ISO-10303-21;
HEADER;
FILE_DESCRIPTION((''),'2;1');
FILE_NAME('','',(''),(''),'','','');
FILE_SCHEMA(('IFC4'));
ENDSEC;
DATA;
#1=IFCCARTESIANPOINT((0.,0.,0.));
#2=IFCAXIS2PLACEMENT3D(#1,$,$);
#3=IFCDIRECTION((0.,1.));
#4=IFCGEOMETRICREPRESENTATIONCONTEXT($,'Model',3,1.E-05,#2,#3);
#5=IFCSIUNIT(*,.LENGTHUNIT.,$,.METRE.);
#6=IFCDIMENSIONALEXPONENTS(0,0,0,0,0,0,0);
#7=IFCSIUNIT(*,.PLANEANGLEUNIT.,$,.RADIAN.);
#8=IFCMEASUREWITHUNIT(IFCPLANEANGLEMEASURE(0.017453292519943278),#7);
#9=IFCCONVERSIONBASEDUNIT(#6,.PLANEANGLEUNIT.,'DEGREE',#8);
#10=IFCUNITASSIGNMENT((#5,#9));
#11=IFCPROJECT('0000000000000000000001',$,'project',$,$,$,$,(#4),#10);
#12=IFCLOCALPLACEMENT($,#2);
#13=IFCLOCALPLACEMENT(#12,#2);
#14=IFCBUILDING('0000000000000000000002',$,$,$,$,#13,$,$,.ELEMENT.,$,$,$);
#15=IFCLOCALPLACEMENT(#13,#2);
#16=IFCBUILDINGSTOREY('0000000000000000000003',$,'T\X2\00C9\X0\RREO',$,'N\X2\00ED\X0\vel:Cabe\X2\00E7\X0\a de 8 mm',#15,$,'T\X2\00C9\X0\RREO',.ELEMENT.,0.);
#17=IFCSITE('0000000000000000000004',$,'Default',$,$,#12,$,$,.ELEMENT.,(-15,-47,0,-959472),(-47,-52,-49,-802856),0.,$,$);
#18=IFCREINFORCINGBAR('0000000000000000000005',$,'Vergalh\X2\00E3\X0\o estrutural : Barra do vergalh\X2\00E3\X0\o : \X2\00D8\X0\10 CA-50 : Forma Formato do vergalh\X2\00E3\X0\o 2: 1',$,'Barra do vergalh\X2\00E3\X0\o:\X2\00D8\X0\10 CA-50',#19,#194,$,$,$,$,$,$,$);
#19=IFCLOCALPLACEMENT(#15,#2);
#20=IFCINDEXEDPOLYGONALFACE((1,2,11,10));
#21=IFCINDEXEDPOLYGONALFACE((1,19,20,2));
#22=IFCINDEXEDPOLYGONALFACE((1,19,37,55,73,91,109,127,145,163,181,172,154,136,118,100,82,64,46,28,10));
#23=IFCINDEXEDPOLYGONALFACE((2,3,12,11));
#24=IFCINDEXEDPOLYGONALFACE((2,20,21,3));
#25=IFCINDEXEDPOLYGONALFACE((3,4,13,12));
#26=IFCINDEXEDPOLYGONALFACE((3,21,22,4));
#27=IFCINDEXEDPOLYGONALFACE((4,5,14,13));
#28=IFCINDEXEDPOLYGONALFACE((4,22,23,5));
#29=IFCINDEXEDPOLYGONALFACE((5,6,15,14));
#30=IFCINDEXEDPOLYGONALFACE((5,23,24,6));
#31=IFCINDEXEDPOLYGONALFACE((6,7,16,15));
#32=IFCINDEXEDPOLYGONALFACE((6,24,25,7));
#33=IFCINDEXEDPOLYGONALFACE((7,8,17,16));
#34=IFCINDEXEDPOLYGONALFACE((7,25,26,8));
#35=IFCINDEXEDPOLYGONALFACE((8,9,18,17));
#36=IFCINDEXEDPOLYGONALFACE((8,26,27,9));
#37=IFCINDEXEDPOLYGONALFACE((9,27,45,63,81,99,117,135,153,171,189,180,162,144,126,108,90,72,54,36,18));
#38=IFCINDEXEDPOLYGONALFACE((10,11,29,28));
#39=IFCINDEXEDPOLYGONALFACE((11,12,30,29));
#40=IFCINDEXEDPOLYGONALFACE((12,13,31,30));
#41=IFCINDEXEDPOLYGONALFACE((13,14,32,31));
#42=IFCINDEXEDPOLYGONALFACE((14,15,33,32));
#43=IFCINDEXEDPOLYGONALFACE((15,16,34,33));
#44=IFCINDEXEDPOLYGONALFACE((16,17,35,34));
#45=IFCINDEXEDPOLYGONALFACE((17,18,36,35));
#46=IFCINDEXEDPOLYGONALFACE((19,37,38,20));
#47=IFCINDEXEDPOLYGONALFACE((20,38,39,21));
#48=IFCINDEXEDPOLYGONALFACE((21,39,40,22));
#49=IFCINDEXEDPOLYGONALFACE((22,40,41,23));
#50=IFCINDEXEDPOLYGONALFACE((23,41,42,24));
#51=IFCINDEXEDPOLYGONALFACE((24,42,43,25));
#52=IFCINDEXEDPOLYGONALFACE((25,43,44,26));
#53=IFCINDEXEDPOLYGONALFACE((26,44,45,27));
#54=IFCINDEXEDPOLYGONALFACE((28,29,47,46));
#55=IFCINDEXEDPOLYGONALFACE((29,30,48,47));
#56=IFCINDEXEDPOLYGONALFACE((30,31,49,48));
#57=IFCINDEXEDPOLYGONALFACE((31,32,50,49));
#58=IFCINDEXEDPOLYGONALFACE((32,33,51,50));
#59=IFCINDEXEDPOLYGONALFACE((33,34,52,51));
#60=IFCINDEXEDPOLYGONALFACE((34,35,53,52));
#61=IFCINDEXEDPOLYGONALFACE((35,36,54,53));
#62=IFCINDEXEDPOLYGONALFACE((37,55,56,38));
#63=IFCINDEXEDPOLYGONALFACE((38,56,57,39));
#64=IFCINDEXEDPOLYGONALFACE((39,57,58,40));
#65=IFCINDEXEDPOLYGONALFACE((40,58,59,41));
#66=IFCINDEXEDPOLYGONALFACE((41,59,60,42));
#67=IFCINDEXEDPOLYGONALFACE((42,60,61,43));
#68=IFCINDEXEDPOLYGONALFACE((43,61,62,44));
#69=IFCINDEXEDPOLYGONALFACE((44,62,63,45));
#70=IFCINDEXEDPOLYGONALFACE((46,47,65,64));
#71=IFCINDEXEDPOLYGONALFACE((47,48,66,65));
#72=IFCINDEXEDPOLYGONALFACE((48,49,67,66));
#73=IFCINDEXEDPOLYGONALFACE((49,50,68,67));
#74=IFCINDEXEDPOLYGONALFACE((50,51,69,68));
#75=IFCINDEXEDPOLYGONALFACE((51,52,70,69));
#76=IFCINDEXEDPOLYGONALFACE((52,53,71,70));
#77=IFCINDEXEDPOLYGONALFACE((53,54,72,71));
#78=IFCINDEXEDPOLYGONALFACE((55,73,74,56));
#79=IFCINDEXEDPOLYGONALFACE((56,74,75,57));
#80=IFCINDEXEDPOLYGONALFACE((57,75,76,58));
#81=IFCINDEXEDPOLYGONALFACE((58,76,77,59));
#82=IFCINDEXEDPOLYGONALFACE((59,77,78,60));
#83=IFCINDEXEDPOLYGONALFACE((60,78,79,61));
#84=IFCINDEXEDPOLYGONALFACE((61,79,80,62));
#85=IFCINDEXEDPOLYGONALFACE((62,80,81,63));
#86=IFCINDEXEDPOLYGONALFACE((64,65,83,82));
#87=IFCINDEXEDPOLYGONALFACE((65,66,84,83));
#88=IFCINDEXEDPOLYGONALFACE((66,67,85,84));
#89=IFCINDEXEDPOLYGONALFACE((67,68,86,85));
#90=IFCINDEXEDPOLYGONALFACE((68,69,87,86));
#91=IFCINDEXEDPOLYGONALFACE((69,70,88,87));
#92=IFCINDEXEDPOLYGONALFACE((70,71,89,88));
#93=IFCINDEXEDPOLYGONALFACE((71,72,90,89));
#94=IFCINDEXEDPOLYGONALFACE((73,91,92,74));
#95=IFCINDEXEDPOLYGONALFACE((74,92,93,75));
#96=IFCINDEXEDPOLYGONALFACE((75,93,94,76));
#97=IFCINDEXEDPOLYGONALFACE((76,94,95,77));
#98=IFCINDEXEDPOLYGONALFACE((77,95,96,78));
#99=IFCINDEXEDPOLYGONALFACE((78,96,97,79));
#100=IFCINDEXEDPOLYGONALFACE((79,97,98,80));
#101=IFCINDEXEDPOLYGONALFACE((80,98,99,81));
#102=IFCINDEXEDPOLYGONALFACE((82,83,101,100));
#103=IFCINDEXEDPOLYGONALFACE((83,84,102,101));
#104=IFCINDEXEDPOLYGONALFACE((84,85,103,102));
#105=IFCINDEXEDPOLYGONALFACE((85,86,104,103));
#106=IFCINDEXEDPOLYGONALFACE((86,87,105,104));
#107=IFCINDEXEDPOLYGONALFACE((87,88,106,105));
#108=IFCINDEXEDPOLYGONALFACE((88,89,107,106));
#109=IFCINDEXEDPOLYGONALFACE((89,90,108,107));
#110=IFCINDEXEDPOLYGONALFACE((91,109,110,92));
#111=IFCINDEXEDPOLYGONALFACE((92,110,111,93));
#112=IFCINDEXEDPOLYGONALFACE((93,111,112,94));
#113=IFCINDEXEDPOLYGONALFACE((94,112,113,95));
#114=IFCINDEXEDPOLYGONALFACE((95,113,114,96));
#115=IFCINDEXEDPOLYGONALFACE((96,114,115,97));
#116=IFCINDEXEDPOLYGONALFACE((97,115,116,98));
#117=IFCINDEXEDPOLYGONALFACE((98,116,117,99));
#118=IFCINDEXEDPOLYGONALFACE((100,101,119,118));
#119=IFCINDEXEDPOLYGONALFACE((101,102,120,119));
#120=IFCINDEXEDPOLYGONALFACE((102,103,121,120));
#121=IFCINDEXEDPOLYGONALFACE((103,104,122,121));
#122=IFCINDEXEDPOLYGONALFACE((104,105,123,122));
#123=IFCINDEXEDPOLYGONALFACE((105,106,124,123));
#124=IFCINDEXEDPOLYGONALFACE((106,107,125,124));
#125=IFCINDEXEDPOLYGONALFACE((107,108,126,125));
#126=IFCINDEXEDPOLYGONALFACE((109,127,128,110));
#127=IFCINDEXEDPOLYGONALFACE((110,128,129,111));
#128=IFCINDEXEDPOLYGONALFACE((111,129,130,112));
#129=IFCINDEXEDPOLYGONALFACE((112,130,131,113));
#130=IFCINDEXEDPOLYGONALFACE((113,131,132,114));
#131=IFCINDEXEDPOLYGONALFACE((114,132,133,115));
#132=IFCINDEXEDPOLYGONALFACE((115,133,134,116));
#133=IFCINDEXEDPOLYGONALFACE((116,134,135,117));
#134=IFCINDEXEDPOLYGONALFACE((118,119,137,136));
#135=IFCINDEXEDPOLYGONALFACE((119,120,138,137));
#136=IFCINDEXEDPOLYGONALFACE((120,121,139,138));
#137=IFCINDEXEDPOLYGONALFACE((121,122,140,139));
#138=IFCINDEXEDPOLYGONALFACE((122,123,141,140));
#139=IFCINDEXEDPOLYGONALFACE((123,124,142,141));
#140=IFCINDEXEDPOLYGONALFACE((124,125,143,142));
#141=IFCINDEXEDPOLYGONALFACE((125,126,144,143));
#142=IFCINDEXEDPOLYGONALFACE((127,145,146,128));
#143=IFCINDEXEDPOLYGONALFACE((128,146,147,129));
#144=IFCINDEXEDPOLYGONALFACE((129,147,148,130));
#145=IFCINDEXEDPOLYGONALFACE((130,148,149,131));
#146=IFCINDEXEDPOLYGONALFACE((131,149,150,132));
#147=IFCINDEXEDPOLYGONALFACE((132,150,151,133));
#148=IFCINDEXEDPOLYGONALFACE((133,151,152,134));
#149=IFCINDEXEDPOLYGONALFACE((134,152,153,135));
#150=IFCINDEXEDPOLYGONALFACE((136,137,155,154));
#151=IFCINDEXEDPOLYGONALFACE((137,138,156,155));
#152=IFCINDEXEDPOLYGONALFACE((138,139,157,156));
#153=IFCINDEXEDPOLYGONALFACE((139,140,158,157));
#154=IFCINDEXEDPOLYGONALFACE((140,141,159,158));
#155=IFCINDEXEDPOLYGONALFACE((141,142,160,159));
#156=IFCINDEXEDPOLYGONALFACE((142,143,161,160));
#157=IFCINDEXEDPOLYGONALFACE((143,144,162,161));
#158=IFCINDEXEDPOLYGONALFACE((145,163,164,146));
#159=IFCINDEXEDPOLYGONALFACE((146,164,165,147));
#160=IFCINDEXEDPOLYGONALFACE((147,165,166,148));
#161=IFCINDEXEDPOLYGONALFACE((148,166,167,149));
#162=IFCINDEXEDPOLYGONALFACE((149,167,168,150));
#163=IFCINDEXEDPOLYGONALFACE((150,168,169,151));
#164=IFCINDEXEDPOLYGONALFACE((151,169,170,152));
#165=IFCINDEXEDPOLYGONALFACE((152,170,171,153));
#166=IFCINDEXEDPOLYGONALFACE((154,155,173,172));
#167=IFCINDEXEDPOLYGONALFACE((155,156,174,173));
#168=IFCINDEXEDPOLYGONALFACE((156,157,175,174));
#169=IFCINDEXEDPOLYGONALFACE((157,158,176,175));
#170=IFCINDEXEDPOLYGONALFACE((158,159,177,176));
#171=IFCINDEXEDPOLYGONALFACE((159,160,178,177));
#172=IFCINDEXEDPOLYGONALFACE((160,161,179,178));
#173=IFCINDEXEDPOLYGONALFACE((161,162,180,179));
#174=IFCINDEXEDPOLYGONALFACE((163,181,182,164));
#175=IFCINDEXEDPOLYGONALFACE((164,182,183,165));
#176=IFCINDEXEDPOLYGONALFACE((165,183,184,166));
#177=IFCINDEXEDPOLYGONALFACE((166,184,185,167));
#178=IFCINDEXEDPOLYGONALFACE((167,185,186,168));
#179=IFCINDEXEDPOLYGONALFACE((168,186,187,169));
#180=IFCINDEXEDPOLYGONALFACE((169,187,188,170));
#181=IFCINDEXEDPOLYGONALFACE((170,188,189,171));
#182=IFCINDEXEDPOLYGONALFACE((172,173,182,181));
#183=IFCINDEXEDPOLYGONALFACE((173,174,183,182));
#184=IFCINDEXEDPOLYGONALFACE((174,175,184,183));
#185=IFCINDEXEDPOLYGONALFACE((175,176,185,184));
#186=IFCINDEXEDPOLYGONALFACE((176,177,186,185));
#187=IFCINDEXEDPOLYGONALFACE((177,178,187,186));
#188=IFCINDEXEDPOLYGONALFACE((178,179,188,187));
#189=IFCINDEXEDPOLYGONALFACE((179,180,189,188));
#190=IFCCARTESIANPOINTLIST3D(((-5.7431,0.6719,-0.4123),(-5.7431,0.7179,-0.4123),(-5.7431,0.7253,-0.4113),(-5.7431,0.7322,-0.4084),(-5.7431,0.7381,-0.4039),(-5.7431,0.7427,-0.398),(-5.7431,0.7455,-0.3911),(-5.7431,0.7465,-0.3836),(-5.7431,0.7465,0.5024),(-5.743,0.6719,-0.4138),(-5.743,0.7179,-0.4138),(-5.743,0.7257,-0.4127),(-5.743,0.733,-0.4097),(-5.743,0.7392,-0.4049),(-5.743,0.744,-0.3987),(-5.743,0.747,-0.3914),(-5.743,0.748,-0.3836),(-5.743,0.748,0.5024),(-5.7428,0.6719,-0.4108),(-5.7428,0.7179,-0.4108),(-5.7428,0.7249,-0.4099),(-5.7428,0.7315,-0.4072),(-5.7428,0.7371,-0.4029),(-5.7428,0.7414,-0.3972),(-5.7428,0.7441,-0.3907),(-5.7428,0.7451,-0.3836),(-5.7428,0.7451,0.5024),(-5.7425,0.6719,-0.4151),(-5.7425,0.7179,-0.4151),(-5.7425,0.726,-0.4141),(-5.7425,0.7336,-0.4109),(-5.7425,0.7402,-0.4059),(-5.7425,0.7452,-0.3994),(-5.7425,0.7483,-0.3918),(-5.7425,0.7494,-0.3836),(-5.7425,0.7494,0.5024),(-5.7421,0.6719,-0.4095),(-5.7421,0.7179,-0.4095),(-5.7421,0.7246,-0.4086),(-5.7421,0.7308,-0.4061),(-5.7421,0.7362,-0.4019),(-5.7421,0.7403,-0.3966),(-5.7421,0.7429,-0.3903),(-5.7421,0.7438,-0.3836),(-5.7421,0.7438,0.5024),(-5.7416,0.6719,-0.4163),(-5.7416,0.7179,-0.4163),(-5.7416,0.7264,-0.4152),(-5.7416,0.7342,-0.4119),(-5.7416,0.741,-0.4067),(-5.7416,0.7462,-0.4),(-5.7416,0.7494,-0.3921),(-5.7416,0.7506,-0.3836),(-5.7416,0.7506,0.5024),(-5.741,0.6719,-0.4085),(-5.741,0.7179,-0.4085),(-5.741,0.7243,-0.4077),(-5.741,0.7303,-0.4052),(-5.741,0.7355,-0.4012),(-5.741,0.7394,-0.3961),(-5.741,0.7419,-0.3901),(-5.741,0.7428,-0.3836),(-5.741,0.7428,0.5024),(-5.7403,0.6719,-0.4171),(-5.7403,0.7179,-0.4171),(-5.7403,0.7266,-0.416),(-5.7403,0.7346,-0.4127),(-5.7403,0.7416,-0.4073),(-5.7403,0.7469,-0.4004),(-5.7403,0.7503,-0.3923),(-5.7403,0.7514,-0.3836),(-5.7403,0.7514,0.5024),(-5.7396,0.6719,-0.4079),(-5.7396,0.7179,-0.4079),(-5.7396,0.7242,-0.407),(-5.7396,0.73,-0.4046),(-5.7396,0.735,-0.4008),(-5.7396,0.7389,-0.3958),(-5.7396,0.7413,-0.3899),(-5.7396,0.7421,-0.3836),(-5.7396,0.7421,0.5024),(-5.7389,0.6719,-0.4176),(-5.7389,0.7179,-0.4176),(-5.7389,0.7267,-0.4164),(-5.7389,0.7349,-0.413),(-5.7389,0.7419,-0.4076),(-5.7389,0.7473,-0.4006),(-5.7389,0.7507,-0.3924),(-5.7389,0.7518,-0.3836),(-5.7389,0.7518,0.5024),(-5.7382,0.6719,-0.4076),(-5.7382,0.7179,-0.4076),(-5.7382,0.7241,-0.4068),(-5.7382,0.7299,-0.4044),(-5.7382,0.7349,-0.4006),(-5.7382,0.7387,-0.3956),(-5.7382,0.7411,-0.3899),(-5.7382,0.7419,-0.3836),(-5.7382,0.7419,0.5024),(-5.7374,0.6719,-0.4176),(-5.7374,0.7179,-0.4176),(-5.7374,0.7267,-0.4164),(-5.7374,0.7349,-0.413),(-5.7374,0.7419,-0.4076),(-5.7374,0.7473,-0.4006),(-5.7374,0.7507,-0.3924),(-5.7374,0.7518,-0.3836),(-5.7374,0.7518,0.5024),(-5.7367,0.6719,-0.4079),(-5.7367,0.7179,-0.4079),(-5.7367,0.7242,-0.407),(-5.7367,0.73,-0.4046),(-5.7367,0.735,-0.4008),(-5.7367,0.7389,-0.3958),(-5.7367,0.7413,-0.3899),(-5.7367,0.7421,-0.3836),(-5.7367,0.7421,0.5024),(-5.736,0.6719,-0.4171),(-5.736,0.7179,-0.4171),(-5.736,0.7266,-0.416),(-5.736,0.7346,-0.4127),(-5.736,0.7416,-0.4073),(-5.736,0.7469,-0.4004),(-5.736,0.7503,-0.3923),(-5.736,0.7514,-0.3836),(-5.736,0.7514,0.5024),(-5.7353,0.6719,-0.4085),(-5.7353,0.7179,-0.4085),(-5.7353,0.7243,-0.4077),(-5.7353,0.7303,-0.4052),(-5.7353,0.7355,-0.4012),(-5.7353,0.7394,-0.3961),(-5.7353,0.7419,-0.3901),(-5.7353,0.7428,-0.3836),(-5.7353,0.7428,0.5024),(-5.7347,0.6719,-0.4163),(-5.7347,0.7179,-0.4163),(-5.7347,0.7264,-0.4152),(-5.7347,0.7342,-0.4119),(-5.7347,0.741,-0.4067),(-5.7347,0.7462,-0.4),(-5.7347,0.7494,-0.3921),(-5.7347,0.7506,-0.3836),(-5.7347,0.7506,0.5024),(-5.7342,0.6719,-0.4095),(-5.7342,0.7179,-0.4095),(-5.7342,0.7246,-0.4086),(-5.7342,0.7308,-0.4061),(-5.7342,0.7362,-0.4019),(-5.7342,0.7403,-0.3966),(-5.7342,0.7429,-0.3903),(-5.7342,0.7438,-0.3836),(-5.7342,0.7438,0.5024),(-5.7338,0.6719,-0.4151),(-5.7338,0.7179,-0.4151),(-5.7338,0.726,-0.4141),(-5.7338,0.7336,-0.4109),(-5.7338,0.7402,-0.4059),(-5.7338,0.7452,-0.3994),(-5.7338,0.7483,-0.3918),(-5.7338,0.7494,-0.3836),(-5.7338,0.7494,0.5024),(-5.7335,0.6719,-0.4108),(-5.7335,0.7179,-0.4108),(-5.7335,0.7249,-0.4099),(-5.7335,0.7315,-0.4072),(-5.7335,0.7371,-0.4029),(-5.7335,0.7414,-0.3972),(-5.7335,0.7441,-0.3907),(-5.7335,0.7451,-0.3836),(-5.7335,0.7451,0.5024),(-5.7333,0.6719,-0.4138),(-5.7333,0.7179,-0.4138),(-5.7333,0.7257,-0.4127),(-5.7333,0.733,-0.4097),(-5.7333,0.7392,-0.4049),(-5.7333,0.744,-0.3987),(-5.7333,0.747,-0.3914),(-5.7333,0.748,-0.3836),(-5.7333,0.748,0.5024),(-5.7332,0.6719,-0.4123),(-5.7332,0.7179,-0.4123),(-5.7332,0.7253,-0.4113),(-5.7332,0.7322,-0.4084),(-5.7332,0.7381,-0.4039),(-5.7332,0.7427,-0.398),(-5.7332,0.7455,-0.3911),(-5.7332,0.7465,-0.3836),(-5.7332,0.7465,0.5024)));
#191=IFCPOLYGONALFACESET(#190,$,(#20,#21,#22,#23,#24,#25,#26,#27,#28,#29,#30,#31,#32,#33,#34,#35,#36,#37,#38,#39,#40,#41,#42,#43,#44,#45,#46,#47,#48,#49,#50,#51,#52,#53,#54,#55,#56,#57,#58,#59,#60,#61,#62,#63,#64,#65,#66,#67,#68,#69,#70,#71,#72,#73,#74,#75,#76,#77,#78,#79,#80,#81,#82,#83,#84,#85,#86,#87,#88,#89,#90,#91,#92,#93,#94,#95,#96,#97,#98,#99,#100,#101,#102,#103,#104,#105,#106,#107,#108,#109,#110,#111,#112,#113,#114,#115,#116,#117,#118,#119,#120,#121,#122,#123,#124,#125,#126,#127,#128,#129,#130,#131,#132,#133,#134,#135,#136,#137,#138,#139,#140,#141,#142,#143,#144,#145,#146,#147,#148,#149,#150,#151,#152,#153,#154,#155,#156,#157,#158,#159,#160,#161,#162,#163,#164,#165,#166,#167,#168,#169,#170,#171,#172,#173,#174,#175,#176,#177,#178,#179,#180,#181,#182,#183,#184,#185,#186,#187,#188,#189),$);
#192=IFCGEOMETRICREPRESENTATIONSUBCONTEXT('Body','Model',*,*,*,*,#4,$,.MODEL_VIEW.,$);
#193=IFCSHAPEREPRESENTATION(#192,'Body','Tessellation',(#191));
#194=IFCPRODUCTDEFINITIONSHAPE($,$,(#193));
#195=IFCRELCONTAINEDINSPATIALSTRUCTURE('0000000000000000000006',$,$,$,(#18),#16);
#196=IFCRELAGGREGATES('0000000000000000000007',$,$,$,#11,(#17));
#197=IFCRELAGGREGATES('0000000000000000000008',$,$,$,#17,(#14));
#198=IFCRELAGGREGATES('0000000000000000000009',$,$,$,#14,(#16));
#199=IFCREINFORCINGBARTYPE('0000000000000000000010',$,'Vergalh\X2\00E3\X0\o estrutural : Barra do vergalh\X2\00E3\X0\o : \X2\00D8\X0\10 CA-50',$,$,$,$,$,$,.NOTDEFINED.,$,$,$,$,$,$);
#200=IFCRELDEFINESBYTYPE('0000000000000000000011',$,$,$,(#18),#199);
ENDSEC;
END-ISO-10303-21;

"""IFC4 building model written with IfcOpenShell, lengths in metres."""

from ifc_helpers import new_model, entity, si_unit, converted_unit, direction, origin, place, context, subcontext, project, spatial, type_object, element, save


model = new_model("IFC4")

# Units and contexts
model_context = context("Model", 3, precision=1e-05, world=origin(), true_north=direction((0.0, 1.0)))
body_context = subcontext(model_context, "Body", "Model", "MODEL_VIEW")
ifc_project = project(units=[si_unit("LENGTHUNIT", "METRE"), converted_unit("PLANEANGLEUNIT", "DEGREE", entity("IfcPlaneAngleMeasure", 0.017453292519943278), si_unit("PLANEANGLEUNIT", "RADIAN"), dimensions=[0, 0, 0, 0, 0, 0, 0])], contexts=[model_context])

# Site, building, storey
site_placement = place(None, origin())
site = spatial("IfcSite", under=ifc_project, at=site_placement, Name="Default", CompositionType="ELEMENT", RefLatitude=(-15, -47, 0, -959472), RefLongitude=(-47, -52, -49, -802856), RefElevation=0.0)
building_placement = place(site_placement, origin())
building = spatial("IfcBuilding", under=site, at=building_placement, CompositionType="ELEMENT")
storey_placement = place(building_placement, origin())
storey = spatial("IfcBuildingStorey", under=building, at=storey_placement, Name="TÉRREO", ObjectType="Nível:Cabeça de 8 mm", LongName="TÉRREO", CompositionType="ELEMENT", Elevation=0.0)

# Reinforcing bar
reinforcing_bar_type_1 = type_object("IfcReinforcingBarType", Name="Vergalhão estrutural : Barra do vergalhão : Ø10 CA-50", PredefinedType="NOTDEFINED")
reinforcing_bar_1_placement = place(storey_placement, origin())
element("IfcReinforcingBar", 1, at=reinforcing_bar_1_placement, inside=storey, type_object=reinforcing_bar_type_1, Name="Vergalhão estrutural : Barra do vergalhão : Ø10 CA-50 : Forma Formato do vergalhão 2: 1", ObjectType="Barra do vergalhão:Ø10 CA-50", context=body_context, shape_type="AdvancedSweptSolid", body=[
    entity("IfcSweptDiskSolid", entity("IfcIndexedPolyCurve", entity("IfcCartesianPointList3D", [[-5.7382, 0.6719, -0.4126], [-5.7382, 0.7179, -0.4126], [-5.7382, 0.7384, -0.4042], [-5.7382, 0.7469, -0.3836], [-5.7382, 0.7469, 0.5024]]), [entity("IfcLineIndex", [1, 2]), entity("IfcArcIndex", [2, 3, 4]), entity("IfcLineIndex", [4, 5])], False), 0.005, None, 0.0, 92.0),
])

save(model, "model.ifc")
